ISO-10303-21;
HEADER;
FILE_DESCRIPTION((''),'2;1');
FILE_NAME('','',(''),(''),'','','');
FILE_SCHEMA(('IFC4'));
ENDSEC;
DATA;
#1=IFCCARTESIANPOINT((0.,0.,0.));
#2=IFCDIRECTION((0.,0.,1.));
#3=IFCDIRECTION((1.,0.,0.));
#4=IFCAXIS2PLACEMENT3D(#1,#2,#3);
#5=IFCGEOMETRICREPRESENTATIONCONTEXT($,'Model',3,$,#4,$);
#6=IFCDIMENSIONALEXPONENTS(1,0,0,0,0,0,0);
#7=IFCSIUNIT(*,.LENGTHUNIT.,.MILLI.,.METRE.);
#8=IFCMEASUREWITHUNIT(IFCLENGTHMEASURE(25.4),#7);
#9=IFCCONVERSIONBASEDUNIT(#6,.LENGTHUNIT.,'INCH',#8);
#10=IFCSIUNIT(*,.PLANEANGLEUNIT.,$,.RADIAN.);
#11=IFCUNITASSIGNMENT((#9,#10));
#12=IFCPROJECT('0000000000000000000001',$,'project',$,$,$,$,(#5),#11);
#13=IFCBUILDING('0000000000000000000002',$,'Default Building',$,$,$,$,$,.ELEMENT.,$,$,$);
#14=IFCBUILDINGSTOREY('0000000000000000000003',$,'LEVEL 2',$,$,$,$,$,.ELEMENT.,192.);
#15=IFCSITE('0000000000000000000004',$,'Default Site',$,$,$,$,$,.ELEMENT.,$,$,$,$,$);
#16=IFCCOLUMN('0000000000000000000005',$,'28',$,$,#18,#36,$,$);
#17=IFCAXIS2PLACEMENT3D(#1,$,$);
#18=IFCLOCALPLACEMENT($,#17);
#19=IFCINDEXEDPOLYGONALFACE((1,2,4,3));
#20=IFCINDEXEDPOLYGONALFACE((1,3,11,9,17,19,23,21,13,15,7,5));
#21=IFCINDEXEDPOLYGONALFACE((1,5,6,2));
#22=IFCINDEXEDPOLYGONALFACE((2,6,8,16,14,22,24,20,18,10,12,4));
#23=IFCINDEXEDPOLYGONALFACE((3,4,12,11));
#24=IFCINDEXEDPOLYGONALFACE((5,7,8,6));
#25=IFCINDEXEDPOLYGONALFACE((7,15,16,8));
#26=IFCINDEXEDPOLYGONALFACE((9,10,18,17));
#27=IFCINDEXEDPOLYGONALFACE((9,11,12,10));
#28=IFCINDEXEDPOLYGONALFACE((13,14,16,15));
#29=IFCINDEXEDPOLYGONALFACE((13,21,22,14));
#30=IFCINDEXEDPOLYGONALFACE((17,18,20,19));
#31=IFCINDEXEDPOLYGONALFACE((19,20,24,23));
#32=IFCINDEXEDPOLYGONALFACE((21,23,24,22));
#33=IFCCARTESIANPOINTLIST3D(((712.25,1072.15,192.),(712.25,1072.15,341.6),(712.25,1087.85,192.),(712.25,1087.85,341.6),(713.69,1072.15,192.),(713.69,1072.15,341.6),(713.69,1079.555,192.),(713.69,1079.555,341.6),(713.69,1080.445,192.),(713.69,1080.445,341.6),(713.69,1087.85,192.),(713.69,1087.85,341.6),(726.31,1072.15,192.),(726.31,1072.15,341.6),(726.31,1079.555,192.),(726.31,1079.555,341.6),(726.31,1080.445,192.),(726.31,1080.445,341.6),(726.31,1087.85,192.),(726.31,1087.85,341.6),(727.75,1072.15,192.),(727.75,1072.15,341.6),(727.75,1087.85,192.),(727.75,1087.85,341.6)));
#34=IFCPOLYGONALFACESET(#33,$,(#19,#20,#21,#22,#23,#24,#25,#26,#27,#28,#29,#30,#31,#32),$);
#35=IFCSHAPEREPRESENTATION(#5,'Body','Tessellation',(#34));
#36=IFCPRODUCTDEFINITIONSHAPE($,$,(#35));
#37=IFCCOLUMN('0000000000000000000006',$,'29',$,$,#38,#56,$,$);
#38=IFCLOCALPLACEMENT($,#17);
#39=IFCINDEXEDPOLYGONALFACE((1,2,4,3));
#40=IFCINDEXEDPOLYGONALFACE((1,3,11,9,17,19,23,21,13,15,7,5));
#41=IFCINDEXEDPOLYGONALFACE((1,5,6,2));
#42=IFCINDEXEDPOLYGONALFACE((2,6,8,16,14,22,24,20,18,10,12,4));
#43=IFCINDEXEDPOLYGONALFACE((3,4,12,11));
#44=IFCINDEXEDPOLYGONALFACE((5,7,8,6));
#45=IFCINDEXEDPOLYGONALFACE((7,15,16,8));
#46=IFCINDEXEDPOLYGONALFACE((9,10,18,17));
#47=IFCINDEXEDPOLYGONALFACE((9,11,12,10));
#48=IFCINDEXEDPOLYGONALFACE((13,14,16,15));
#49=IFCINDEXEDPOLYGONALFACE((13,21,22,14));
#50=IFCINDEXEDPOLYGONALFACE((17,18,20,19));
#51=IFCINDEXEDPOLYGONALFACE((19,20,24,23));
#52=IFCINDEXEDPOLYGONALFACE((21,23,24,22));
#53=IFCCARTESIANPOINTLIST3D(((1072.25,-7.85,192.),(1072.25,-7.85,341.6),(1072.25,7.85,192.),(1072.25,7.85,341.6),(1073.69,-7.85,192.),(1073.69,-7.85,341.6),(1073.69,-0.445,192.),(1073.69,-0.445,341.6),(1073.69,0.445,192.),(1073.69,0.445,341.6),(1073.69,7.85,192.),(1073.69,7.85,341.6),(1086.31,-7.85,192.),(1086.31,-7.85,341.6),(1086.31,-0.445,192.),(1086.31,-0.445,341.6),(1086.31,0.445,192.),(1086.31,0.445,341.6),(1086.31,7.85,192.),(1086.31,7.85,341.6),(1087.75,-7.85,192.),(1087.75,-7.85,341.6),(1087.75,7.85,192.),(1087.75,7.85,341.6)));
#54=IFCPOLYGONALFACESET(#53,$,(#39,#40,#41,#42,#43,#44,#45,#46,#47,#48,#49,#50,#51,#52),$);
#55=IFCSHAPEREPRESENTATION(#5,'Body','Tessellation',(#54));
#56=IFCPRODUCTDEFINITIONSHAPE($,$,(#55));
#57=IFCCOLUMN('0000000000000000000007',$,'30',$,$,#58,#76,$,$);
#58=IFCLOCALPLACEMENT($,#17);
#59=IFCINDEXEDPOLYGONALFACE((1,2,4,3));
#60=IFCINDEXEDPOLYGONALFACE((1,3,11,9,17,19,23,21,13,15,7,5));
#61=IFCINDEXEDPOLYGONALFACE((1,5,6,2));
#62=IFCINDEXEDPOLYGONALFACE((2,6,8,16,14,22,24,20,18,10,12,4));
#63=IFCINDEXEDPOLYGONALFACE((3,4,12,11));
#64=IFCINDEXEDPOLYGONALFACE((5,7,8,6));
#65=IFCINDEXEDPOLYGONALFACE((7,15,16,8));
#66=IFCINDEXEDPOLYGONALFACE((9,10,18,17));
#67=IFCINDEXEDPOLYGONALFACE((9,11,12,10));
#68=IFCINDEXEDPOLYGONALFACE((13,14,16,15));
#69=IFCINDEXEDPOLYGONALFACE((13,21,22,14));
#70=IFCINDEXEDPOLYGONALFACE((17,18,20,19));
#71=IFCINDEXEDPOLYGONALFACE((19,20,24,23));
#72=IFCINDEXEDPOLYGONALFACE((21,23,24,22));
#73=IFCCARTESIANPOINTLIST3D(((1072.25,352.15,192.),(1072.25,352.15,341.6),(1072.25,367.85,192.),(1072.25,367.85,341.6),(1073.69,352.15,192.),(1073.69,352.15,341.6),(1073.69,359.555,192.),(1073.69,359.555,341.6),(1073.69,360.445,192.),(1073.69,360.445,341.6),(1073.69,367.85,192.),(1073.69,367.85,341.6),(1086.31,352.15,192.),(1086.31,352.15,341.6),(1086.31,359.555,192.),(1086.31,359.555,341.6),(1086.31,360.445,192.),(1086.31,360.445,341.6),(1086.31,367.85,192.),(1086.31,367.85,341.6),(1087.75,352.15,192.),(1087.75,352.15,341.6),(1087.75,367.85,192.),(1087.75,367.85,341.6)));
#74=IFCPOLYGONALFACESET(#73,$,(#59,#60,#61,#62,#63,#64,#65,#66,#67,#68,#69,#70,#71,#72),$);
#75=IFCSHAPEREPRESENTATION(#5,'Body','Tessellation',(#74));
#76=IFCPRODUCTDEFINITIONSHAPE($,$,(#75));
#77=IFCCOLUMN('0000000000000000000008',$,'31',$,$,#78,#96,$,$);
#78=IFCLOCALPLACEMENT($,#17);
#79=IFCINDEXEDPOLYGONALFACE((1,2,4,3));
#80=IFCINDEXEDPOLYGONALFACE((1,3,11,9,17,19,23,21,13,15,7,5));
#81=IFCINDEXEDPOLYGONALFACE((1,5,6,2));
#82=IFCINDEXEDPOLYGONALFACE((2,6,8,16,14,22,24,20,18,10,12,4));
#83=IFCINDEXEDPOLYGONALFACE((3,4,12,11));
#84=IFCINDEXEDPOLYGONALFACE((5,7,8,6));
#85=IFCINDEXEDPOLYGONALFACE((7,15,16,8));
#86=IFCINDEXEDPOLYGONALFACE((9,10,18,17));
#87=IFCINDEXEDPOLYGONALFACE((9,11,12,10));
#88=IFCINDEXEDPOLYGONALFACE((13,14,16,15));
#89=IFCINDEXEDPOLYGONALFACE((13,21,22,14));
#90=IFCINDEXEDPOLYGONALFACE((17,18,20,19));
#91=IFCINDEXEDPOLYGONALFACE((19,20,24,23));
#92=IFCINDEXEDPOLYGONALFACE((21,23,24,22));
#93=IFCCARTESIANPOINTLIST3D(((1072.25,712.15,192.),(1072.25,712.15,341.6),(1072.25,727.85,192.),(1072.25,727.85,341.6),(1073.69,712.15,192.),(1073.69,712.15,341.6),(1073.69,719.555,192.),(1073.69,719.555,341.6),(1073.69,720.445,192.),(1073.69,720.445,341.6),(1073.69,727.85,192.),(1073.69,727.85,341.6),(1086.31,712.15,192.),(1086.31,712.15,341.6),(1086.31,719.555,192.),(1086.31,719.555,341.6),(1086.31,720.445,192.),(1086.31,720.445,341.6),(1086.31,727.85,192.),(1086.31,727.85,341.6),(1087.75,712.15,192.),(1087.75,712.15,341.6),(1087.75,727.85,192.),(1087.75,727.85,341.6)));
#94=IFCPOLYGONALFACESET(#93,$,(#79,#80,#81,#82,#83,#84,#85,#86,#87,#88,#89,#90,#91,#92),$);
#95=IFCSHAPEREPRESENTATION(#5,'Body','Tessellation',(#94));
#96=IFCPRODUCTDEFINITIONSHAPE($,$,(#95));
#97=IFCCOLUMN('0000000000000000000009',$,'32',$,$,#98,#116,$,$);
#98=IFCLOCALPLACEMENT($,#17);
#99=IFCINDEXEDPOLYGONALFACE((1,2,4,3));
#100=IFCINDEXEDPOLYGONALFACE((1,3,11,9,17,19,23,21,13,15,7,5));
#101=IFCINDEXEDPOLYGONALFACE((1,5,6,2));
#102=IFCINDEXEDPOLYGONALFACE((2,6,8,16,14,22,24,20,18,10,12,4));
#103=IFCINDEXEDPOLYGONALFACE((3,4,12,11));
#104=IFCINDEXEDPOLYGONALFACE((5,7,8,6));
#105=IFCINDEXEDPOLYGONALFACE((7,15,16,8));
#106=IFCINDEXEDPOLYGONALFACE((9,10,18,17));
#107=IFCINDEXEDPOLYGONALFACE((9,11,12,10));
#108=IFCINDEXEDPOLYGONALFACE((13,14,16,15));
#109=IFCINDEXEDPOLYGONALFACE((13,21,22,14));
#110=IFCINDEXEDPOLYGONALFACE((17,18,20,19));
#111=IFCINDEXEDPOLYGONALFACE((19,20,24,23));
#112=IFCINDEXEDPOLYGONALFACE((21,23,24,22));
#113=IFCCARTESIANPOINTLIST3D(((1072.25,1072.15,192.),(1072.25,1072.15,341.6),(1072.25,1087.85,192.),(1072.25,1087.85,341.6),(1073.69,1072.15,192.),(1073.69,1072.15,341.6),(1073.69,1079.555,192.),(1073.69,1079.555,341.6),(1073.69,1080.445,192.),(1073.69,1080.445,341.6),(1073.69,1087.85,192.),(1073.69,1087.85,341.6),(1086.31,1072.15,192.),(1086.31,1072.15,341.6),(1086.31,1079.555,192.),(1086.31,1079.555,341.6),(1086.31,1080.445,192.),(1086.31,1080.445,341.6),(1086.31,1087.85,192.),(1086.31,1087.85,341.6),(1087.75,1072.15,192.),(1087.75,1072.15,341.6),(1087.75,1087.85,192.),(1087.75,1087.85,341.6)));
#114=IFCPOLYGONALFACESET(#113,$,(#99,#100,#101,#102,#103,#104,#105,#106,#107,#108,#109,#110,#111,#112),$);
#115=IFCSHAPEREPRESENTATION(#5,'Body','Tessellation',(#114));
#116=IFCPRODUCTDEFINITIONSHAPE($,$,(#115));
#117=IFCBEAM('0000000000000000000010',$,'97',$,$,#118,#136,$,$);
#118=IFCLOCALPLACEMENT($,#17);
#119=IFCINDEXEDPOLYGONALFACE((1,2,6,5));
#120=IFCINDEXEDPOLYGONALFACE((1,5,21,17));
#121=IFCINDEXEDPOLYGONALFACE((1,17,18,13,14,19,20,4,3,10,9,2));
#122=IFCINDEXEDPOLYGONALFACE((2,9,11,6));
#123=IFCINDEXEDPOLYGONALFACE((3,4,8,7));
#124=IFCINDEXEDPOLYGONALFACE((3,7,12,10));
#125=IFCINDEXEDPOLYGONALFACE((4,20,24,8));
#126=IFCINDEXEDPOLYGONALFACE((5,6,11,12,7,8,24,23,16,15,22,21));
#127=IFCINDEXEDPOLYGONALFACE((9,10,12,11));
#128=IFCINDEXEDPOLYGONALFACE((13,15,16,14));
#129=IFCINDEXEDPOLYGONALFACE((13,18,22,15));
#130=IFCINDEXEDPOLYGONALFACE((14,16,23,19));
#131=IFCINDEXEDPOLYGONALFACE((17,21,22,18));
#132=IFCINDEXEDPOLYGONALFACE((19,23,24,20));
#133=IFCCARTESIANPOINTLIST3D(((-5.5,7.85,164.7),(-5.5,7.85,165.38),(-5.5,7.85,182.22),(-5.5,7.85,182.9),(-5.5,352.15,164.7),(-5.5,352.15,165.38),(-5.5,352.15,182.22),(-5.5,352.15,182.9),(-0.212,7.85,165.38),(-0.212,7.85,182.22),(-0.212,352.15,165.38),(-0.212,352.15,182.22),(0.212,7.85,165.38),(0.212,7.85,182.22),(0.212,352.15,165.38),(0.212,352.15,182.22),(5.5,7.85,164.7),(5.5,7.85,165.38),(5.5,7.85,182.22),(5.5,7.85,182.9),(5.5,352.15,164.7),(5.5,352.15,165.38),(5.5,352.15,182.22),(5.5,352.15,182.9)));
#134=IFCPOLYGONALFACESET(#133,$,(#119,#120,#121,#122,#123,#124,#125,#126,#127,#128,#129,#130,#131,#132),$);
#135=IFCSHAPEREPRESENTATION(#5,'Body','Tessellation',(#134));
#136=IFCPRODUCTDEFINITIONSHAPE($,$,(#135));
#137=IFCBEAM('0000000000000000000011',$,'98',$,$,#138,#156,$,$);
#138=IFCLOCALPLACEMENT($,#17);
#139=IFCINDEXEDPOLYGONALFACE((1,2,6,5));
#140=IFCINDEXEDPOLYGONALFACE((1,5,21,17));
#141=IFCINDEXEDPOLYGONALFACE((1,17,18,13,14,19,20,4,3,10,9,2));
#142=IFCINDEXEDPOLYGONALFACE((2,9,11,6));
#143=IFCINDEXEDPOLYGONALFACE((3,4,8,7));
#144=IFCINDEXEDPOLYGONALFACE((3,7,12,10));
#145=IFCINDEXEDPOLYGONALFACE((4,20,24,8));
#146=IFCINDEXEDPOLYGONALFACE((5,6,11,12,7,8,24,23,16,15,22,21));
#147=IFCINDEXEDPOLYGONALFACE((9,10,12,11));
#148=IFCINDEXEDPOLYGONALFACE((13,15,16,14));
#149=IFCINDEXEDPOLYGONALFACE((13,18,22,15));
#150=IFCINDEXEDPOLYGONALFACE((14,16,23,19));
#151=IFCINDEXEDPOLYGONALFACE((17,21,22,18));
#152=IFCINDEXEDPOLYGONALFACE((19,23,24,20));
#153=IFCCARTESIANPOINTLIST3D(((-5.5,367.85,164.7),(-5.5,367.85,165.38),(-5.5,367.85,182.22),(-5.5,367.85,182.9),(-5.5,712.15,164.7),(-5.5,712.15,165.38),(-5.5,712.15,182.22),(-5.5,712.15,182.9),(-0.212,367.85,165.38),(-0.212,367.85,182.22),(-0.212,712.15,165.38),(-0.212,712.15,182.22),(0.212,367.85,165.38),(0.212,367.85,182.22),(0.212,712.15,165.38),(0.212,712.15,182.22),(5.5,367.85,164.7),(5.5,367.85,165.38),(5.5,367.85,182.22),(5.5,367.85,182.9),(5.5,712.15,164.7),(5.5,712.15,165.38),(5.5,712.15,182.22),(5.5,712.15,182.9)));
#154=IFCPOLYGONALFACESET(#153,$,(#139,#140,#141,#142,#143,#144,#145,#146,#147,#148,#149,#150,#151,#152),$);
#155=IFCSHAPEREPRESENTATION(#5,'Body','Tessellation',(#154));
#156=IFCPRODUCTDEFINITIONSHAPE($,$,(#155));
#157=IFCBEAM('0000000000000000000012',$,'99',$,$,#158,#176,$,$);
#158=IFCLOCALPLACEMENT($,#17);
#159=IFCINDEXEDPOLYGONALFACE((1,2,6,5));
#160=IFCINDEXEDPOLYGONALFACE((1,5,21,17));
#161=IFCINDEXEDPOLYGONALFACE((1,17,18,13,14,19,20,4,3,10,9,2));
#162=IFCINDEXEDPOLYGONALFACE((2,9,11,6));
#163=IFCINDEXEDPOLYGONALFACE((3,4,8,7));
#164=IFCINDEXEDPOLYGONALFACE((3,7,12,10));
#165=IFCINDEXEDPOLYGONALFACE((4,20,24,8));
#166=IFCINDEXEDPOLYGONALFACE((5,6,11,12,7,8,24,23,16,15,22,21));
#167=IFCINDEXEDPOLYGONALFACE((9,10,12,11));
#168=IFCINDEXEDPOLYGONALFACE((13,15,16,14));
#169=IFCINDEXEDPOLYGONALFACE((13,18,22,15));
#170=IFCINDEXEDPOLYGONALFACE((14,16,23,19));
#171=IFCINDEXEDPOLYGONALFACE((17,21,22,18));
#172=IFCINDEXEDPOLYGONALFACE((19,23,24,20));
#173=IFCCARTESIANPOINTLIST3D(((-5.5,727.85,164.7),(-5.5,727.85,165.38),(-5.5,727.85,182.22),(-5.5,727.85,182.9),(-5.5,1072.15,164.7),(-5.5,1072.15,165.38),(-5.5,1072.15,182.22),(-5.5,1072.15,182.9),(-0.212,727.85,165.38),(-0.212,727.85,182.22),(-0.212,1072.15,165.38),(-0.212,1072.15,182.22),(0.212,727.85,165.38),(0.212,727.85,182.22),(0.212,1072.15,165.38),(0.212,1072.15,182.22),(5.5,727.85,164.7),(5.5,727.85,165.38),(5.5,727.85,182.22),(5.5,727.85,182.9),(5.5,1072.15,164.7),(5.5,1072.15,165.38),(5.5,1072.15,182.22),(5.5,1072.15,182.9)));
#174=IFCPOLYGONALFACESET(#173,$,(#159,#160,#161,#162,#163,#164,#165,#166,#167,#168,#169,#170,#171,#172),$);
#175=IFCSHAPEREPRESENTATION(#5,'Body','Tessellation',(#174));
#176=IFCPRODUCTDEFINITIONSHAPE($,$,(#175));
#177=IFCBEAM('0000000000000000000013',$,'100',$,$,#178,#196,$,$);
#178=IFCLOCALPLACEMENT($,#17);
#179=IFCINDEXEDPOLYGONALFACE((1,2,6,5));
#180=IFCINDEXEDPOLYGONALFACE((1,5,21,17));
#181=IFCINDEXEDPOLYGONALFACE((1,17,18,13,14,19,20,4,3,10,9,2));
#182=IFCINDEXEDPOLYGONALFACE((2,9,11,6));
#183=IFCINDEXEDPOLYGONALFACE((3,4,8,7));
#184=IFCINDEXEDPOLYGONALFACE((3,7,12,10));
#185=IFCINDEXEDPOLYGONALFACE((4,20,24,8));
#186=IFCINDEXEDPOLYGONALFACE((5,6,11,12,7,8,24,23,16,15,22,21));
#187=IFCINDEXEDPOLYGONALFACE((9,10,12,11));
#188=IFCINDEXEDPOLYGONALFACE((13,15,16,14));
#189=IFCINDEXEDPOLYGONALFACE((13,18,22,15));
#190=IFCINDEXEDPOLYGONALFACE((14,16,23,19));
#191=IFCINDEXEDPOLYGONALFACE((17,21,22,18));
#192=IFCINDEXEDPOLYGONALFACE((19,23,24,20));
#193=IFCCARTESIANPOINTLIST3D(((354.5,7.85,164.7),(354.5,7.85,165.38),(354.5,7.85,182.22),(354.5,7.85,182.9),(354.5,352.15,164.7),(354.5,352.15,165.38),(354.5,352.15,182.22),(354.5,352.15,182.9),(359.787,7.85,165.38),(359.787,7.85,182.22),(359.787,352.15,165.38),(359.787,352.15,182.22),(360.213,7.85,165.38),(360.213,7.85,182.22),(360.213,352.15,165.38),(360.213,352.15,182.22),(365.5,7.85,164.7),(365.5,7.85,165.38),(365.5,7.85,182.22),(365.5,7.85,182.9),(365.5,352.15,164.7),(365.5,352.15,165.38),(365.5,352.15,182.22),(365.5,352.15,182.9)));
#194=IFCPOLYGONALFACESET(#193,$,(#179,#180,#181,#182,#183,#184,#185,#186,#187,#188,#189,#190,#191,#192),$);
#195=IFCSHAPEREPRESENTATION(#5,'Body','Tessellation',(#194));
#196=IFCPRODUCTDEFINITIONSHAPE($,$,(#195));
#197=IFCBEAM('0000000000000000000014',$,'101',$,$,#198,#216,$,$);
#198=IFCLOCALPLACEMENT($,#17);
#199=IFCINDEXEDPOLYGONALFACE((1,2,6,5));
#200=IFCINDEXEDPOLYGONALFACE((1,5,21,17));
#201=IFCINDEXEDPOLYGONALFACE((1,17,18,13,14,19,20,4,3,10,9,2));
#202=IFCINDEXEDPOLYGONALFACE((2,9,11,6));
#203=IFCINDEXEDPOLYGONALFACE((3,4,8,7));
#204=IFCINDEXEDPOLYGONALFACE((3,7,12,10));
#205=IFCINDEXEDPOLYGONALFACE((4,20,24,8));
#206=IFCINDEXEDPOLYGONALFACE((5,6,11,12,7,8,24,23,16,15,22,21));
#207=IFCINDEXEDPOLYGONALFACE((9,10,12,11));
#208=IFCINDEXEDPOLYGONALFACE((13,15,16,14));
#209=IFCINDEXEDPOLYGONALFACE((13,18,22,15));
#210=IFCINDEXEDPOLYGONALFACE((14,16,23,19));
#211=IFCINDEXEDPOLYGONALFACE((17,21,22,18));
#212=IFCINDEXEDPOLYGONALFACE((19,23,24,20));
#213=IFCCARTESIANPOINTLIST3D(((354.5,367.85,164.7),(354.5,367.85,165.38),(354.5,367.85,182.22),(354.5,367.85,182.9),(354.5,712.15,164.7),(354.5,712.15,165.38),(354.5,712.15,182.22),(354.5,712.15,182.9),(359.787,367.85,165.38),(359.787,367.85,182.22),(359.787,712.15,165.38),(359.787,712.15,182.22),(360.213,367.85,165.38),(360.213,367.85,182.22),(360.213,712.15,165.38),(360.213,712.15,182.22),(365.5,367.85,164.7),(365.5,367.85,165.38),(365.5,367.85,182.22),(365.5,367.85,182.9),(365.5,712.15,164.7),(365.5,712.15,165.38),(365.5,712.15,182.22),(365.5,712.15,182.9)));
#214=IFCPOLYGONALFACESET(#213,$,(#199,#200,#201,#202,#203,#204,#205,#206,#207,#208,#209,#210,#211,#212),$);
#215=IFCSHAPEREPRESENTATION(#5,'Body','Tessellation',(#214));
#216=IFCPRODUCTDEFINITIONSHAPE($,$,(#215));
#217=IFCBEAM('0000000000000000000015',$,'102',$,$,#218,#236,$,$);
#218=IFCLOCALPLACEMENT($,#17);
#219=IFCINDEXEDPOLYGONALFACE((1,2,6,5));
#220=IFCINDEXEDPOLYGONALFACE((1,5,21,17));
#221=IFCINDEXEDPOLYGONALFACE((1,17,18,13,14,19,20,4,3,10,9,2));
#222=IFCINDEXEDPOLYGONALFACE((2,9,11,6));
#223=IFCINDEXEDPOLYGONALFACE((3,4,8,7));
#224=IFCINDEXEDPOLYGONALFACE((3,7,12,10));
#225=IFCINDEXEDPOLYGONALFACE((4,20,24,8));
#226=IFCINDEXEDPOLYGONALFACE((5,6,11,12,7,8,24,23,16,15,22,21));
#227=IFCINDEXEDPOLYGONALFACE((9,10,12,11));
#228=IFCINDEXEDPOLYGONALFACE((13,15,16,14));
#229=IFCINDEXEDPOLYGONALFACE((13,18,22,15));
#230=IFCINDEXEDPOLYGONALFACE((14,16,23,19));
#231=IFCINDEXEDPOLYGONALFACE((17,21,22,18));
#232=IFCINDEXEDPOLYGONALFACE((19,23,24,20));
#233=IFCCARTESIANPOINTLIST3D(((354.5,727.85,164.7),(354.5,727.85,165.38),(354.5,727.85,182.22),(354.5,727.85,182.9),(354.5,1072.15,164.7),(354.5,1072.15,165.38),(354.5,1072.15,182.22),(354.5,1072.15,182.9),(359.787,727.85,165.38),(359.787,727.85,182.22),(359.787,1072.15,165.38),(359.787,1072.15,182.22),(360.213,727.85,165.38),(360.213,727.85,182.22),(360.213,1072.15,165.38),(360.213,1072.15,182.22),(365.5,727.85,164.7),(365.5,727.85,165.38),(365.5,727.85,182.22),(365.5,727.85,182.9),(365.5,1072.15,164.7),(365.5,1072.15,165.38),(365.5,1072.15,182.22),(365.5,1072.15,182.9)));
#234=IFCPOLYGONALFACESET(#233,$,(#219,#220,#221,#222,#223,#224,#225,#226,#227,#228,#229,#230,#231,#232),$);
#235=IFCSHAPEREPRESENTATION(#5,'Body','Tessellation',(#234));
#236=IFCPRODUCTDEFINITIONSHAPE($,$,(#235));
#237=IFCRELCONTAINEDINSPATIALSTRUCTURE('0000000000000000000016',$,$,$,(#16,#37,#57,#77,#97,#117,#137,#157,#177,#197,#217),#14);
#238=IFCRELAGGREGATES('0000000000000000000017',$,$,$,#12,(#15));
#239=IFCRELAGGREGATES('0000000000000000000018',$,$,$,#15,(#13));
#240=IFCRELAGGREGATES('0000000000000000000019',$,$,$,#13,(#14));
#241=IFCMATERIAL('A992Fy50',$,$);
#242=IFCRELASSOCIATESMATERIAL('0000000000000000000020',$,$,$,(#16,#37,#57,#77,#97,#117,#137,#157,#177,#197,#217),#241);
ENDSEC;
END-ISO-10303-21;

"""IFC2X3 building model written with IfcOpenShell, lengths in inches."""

from ifc_helpers import new_model, entity, si_unit, converted_unit, frame, origin_with_axes, origin_2d_with_axis, place, context, project, spatial, i_section, transform_2d, derived_profile, extrude, material, element, save


model = new_model("IFC2X3")

# Units and contexts
model_context = context("Model", 3, world=origin_with_axes())
ifc_project = project(units=[converted_unit("LENGTHUNIT", "INCH", entity("IfcLengthMeasure", 25.4), si_unit("LENGTHUNIT", "METRE", prefix="MILLI"), dimensions=[1, 0, 0, 0, 0, 0, 0]), si_unit("PLANEANGLEUNIT", "RADIAN")], contexts=[model_context])

# Site, building, storey
site = spatial("IfcSite", under=ifc_project, Name="Default Site", CompositionType="ELEMENT")
building = spatial("IfcBuilding", under=site, Name="Default Building", CompositionType="ELEMENT")
storey = spatial("IfcBuildingStorey", under=building, Name="LEVEL 2", CompositionType="ELEMENT", Elevation=192.0)

# Columns
ifc_material = material(Name="A992Fy50")
for number, where, z_axis, x_axis, name in (
    (1, (720.0, 1080.0, 192.0), (0.0, 0.0, 1.0), (0.0, -1.0, 0.0), "28"),
    (2, (1080.0, 0.0, 192.0), (0.0, 0.0, 1.0), (0.0, -1.0, 0.0), "29"),
    (3, (1080.0, 360.0, 192.0), (0.0, 0.0, 1.0), (0.0, -1.0, 0.0), "30"),
    (4, (1080.0, 720.0, 192.0), (0.0, 0.0, 1.0), (0.0, -1.0, 0.0), "31"),
    (5, (1080.0, 1080.0, 192.0), (0.0, 0.0, 1.0), (0.0, -1.0, 0.0), "32"),
):
    element("IfcColumn", number, at=place(None, frame(where, z_axis=z_axis, x_axis=x_axis)), inside=storey, material=ifc_material, Name=name, context=model_context, shape_type="SweptSolid", body=[
        extrude(i_section(OverallWidth=15.7, OverallDepth=15.5, WebThickness=0.89, FlangeThickness=1.44, at=origin_2d_with_axis()), origin_with_axes(), (0.0, 0.0, 1.0), 149.6),
    ])

# Beams
for number, where, z_axis, x_axis, name in (
    (6, (0.0, 7.85, 192.0), (0.0, 1.0, 0.0), (-1.0, 0.0, 0.0), "97"),
    (7, (0.0, 367.85, 192.0), (0.0, 1.0, 0.0), (-1.0, 0.0, 0.0), "98"),
    (8, (0.0, 727.85, 192.0), (0.0, 1.0, 0.0), (-1.0, 0.0, 0.0), "99"),
    (9, (360.0, 7.85, 192.0), (0.0, 1.0, 0.0), (-1.0, 0.0, 0.0), "100"),
    (10, (360.0, 367.85, 192.0), (0.0, 1.0, 0.0), (-1.0, 0.0, 0.0), "101"),
    (11, (360.0, 727.85, 192.0), (0.0, 1.0, 0.0), (-1.0, 0.0, 0.0), "102"),
):
    element("IfcBeam", number, at=place(None, frame(where, z_axis=z_axis, x_axis=x_axis)), inside=storey, material=ifc_material, Name=name, context=model_context, shape_type="SweptSolid", body=[
        extrude(derived_profile(i_section(OverallWidth=11.0, OverallDepth=18.2, WebThickness=0.425, FlangeThickness=0.68, at=origin_2d_with_axis()), transform_2d((0.0, -9.1))), origin_with_axes(), (0.0, 0.0, 1.0), 344.3),
    ])

save(model, "model.ifc")
